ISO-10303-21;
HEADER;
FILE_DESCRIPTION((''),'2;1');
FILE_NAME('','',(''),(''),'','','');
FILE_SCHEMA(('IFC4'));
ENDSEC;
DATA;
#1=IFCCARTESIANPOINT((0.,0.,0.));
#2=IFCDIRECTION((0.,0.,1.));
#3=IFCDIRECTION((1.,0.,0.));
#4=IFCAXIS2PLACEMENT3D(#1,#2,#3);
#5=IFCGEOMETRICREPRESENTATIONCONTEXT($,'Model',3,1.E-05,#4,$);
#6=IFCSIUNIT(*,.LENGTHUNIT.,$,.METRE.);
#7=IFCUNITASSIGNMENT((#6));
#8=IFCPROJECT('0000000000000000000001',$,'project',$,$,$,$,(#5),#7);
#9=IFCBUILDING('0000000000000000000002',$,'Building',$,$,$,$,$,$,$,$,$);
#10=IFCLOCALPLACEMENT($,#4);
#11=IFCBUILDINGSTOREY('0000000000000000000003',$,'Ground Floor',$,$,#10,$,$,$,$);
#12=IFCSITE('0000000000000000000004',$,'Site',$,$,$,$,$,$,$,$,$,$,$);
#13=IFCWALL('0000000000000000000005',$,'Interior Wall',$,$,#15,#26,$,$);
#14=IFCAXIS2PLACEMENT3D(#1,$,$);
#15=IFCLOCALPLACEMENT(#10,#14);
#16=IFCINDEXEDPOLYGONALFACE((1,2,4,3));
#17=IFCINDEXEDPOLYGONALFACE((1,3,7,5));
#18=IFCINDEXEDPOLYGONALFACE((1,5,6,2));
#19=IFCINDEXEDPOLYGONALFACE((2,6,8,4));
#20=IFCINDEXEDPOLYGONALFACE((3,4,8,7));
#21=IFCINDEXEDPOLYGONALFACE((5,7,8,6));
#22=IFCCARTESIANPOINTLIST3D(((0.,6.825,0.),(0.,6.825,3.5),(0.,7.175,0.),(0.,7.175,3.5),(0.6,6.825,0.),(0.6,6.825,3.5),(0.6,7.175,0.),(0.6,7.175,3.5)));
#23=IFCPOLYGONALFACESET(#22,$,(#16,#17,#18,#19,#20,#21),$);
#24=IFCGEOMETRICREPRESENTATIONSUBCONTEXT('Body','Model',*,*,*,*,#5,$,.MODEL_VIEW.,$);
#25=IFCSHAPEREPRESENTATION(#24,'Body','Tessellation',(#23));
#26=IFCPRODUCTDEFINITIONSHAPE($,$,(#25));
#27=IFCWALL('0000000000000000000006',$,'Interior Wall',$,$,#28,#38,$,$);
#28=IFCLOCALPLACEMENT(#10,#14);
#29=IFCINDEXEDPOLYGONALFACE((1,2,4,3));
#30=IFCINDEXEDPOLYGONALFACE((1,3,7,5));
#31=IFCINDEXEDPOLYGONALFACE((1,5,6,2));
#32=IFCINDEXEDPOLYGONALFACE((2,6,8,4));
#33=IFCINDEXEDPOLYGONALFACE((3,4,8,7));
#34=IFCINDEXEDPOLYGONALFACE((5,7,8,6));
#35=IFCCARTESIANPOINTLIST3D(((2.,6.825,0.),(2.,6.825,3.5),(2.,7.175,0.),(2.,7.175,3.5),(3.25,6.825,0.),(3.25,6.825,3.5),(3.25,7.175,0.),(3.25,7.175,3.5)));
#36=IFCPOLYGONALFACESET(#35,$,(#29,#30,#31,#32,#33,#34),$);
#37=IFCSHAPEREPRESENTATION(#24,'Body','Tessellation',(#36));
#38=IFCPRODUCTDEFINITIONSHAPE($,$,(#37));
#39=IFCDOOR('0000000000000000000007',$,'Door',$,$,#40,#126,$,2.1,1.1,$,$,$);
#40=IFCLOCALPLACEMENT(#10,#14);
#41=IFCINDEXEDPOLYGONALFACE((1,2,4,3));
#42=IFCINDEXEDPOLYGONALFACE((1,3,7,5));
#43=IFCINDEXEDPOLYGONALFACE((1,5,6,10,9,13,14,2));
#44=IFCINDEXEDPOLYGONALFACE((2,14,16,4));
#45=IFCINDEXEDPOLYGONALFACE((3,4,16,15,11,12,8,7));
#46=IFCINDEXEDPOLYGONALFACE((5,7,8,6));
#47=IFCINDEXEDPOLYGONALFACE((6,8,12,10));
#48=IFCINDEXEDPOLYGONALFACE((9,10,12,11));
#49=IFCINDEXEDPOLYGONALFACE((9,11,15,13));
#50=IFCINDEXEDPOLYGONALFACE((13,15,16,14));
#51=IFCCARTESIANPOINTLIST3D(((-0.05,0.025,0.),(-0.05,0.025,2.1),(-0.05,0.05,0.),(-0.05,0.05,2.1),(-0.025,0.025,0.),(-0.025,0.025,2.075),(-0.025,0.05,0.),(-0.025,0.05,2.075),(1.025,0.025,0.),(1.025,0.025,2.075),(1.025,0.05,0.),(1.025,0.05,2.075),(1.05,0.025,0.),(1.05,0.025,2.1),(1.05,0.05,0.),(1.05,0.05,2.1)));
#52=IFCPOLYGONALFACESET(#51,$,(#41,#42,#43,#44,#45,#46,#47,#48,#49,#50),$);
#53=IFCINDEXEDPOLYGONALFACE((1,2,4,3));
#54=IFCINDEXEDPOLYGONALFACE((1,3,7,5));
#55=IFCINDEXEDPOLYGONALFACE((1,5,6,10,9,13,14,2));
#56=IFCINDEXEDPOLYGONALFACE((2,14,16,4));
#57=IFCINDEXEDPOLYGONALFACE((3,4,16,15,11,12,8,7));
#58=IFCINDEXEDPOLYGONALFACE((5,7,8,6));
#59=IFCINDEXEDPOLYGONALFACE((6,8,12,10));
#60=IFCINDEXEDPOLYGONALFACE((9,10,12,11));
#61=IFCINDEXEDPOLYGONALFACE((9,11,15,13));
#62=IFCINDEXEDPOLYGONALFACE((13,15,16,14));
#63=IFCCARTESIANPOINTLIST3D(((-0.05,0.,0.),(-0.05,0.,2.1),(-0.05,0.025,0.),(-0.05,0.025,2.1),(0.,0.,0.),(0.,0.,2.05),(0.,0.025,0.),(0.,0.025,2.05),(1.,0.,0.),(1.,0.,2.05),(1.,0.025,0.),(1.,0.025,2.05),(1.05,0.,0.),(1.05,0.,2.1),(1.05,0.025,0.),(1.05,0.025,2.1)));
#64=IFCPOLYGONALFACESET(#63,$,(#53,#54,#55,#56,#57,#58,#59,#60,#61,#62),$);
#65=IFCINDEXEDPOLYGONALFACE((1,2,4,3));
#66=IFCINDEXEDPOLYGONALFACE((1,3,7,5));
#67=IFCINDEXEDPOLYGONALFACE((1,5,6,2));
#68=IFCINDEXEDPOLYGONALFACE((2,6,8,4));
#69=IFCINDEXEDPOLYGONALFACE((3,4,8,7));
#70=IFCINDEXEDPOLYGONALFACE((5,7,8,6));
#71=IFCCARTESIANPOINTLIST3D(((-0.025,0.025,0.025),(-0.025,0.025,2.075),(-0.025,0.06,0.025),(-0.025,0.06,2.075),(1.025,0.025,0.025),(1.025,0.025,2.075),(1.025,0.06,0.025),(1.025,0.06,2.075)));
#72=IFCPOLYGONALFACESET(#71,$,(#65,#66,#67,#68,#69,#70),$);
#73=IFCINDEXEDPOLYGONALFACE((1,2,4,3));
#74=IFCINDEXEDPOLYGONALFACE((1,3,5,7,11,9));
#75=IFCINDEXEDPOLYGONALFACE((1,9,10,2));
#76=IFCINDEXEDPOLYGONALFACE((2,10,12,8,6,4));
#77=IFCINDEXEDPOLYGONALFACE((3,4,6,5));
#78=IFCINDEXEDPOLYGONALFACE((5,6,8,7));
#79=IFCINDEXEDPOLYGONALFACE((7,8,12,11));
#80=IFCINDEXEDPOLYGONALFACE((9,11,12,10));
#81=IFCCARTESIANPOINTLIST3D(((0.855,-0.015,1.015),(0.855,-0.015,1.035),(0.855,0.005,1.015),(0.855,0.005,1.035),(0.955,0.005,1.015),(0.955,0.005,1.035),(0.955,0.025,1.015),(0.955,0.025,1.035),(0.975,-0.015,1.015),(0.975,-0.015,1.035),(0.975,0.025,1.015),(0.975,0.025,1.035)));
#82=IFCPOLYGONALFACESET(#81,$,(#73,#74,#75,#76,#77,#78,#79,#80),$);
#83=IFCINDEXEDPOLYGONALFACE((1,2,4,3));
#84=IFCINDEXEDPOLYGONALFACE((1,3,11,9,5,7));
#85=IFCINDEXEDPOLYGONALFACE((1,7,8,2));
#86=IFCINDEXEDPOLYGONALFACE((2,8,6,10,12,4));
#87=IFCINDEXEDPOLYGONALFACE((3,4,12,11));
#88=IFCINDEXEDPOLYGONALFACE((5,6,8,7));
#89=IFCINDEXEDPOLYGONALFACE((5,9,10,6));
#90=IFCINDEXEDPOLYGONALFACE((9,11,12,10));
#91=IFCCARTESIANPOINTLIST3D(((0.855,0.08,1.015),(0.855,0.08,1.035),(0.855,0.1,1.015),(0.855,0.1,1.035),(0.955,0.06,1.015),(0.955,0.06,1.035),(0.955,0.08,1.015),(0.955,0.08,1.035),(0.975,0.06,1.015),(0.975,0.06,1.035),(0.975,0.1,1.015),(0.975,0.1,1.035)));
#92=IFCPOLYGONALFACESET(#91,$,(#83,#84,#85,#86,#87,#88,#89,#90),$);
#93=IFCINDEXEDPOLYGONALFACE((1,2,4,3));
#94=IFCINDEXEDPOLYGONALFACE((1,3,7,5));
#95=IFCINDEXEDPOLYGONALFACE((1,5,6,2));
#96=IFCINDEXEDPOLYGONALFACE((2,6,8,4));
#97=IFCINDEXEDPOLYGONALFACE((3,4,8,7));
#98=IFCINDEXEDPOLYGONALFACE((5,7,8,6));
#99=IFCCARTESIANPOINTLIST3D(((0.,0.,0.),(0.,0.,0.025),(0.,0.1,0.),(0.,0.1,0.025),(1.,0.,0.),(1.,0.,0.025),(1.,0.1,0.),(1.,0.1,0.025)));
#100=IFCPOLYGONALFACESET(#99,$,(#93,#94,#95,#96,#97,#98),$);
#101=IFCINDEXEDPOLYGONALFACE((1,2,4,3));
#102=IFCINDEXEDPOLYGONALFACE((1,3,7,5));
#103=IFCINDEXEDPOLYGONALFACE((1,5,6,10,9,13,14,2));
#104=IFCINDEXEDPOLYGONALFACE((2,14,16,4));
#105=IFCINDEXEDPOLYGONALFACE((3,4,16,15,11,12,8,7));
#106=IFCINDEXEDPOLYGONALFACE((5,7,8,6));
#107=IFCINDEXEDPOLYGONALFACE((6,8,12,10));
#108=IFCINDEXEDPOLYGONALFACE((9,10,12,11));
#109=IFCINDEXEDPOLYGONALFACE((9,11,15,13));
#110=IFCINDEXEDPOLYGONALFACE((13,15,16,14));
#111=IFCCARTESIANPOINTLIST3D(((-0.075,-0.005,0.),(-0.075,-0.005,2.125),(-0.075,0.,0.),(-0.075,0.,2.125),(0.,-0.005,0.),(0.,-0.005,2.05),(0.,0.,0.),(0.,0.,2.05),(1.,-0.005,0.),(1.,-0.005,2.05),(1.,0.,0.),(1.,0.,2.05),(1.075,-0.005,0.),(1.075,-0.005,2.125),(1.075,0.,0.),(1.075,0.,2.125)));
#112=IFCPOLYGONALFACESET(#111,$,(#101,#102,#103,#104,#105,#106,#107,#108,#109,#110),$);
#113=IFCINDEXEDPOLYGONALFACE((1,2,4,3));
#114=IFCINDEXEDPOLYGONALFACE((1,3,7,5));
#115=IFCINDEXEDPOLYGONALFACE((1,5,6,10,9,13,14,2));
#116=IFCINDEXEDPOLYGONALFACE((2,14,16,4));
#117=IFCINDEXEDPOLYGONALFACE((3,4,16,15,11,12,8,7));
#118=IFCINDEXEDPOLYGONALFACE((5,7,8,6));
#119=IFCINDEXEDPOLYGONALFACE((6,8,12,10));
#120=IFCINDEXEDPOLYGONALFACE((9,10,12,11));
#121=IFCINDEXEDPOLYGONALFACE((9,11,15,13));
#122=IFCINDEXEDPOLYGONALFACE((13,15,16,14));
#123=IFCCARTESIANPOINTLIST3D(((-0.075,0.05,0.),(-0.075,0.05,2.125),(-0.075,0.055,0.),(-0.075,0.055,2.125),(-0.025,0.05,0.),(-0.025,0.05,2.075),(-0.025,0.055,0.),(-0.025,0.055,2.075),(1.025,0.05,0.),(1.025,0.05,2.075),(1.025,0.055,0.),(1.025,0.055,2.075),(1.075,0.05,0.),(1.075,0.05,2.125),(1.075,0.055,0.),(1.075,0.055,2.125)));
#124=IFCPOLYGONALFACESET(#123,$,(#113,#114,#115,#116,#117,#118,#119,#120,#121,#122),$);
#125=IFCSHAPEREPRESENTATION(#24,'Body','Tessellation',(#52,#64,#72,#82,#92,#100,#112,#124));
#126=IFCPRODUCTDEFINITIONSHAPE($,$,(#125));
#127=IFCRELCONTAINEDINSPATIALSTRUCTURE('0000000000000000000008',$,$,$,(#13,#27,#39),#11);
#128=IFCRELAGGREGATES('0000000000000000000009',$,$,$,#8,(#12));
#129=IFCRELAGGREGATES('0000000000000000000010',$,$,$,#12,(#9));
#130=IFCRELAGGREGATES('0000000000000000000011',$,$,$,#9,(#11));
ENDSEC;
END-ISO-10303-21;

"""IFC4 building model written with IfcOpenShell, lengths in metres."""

from ifc_helpers import new_model, si_unit, frame, origin_with_axes, place, context, subcontext, project, spatial, line, indexed_curve, outline, extrude, element, save


model = new_model("IFC4")

# Units and contexts
model_context = context("Model", 3, precision=1e-05, world=origin_with_axes())
body_context = subcontext(model_context, "Body", "Model", "MODEL_VIEW")
ifc_project = project(units=[si_unit("LENGTHUNIT", "METRE")], contexts=[model_context])

# Site, building, storey
site = spatial("IfcSite", under=ifc_project, Name="Site")
building = spatial("IfcBuilding", under=site, Name="Building")
storey_placement = place(None, origin_with_axes())
storey = spatial("IfcBuildingStorey", under=building, at=storey_placement, Name="Ground Floor")

# Walls
for number, where, z_axis, x_axis, name in (
    (1, (0.6, 7.0, 0.0), (0.0, 0.0, 1.0), (-1.0, 0.0, 0.0), "Interior Wall"),
):
    element("IfcWall", number, at=place(storey_placement, frame(where, z_axis=z_axis, x_axis=x_axis)), inside=storey, Name=name, context=body_context, shape_type="SweptSolid", body=[
        extrude(outline(indexed_curve([(0.0, 0.0), (0.0, 0.35), (0.6, 0.35), (0.6, 0.0), (0.0, 0.0)], self_intersect=False)), frame((0.0, -0.175, 0.0), z_axis=(0.0, 0.0, 1.0), x_axis=(1.0, 0.0, 0.0)), (0.0, 0.0, 1.0), 3.5),
    ])
wall_1_placement = place(storey_placement, frame((3.25, 7.0, 0.0), z_axis=(0.0, 0.0, 1.0), x_axis=(-1.0, 0.0, 0.0)))
element("IfcWall", 2, at=wall_1_placement, inside=storey, Name="Interior Wall", context=body_context, shape_type="SweptSolid", body=[
    extrude(outline(indexed_curve([(0.0, 0.0), (0.0, 0.35), (1.25, 0.35), (1.25, 0.0), (0.0, 0.0)], self_intersect=False)), frame((0.0, -0.175, 0.0), z_axis=(0.0, 0.0, 1.0), x_axis=(1.0, 0.0, 0.0)), (0.0, 0.0, 1.0), 3.5),
])

# Door
door_1_placement = place(storey_placement, frame((-0.05, 0.0, 0.0), z_axis=(0.0, 0.0, 1.0), x_axis=(1.0, 0.0, 0.0)))
element("IfcDoor", 3, at=door_1_placement, inside=storey, Name="Door", OverallHeight=2.1, OverallWidth=1.1, context=body_context, shape_type="SweptSolid", body=[
    extrude(outline(indexed_curve([(0.0, 0.0), (0.0, 2.1), (1.1, 2.1), (1.1, 0.0), (1.075, 0.0), (1.075, 2.075), (0.025, 2.075), (0.025, 0.0)], segments=[line(1, 2, 3, 4, 5, 6, 7, 8, 1)])), frame((0.0, 0.025, 0.0), z_axis=(0.0, -1.0, 0.0), x_axis=(1.0, 0.0, 0.0)), (0.0, 0.0, -1.0), 0.025),
    extrude(outline(indexed_curve([(0.0, 0.0), (0.0, 2.1), (1.1, 2.1), (1.1, 0.0), (1.05, 0.0), (1.05, 2.05), (0.05, 2.05), (0.05, 0.0)], segments=[line(1, 2, 3, 4, 5, 6, 7, 8, 1)])), frame((0.0, 0.0, 0.0), z_axis=(0.0, -1.0, 0.0), x_axis=(1.0, 0.0, 0.0)), (0.0, 0.0, -1.0), 0.025),
    extrude(outline(indexed_curve([(0.0, 0.0), (1.05, 0.0), (1.05, 0.035), (0.0, 0.035)], segments=[line(1, 2, 3, 4, 1)])), frame((0.025, 0.025, 0.025), z_axis=(0.0, 0.0, 1.0), x_axis=(1.0, 0.0, 0.0)), (0.0, 0.0, 1.0), 2.05),
    extrude(outline(indexed_curve([(0.0, 0.0), (0.0, -0.04), (-0.12, -0.04), (-0.12, -0.02), (-0.02, -0.02), (-0.02, 0.0)], segments=[line(1, 2, 3, 4, 5, 6, 1)])), frame((1.025, 0.025, 1.015), z_axis=(0.0, 0.0, 1.0), x_axis=(1.0, 0.0, 0.0)), (0.0, 0.0, 1.0), 0.02),
    extrude(outline(indexed_curve([(0.0, 0.0), (0.0, 0.04), (-0.12, 0.04), (-0.12, 0.02), (-0.02, 0.02), (-0.02, 0.0)], segments=[line(1, 2, 3, 4, 5, 6, 1)])), frame((1.025, 0.06, 1.015), z_axis=(0.0, 0.0, 1.0), x_axis=(1.0, 0.0, 0.0)), (0.0, 0.0, 1.0), 0.02),
    extrude(outline(indexed_curve([(0.0, 0.0), (1.0, 0.0), (1.0, 0.1), (0.0, 0.1)], segments=[line(1, 2, 3, 4, 1)])), frame((0.05, 0.0, 0.0), z_axis=(0.0, 0.0, 1.0), x_axis=(1.0, 0.0, 0.0)), (0.0, 0.0, 1.0), 0.025),
    extrude(outline(indexed_curve([(0.0, 0.0), (0.0, 2.125), (1.15, 2.125), (1.15, 0.0), (1.075, 0.0), (1.075, 2.05), (0.075, 2.05), (0.075, 0.0)], segments=[line(1, 2, 3, 4, 5, 6, 7, 8, 1)])), frame((-0.025, -0.005, 0.0), z_axis=(0.0, -1.0, 0.0), x_axis=(1.0, 0.0, 0.0)), (0.0, 0.0, -1.0), 0.005),
    extrude(outline(indexed_curve([(0.0, 0.0), (0.0, 2.125), (1.15, 2.125), (1.15, 0.0), (1.1, 0.0), (1.1, 2.075), (0.05, 2.075), (0.05, 0.0)], segments=[line(1, 2, 3, 4, 5, 6, 7, 8, 1)])), frame((-0.025, 0.05, 0.0), z_axis=(0.0, -1.0, 0.0), x_axis=(1.0, 0.0, 0.0)), (0.0, 0.0, -1.0), 0.005),
])

save(model, "model.ifc")
